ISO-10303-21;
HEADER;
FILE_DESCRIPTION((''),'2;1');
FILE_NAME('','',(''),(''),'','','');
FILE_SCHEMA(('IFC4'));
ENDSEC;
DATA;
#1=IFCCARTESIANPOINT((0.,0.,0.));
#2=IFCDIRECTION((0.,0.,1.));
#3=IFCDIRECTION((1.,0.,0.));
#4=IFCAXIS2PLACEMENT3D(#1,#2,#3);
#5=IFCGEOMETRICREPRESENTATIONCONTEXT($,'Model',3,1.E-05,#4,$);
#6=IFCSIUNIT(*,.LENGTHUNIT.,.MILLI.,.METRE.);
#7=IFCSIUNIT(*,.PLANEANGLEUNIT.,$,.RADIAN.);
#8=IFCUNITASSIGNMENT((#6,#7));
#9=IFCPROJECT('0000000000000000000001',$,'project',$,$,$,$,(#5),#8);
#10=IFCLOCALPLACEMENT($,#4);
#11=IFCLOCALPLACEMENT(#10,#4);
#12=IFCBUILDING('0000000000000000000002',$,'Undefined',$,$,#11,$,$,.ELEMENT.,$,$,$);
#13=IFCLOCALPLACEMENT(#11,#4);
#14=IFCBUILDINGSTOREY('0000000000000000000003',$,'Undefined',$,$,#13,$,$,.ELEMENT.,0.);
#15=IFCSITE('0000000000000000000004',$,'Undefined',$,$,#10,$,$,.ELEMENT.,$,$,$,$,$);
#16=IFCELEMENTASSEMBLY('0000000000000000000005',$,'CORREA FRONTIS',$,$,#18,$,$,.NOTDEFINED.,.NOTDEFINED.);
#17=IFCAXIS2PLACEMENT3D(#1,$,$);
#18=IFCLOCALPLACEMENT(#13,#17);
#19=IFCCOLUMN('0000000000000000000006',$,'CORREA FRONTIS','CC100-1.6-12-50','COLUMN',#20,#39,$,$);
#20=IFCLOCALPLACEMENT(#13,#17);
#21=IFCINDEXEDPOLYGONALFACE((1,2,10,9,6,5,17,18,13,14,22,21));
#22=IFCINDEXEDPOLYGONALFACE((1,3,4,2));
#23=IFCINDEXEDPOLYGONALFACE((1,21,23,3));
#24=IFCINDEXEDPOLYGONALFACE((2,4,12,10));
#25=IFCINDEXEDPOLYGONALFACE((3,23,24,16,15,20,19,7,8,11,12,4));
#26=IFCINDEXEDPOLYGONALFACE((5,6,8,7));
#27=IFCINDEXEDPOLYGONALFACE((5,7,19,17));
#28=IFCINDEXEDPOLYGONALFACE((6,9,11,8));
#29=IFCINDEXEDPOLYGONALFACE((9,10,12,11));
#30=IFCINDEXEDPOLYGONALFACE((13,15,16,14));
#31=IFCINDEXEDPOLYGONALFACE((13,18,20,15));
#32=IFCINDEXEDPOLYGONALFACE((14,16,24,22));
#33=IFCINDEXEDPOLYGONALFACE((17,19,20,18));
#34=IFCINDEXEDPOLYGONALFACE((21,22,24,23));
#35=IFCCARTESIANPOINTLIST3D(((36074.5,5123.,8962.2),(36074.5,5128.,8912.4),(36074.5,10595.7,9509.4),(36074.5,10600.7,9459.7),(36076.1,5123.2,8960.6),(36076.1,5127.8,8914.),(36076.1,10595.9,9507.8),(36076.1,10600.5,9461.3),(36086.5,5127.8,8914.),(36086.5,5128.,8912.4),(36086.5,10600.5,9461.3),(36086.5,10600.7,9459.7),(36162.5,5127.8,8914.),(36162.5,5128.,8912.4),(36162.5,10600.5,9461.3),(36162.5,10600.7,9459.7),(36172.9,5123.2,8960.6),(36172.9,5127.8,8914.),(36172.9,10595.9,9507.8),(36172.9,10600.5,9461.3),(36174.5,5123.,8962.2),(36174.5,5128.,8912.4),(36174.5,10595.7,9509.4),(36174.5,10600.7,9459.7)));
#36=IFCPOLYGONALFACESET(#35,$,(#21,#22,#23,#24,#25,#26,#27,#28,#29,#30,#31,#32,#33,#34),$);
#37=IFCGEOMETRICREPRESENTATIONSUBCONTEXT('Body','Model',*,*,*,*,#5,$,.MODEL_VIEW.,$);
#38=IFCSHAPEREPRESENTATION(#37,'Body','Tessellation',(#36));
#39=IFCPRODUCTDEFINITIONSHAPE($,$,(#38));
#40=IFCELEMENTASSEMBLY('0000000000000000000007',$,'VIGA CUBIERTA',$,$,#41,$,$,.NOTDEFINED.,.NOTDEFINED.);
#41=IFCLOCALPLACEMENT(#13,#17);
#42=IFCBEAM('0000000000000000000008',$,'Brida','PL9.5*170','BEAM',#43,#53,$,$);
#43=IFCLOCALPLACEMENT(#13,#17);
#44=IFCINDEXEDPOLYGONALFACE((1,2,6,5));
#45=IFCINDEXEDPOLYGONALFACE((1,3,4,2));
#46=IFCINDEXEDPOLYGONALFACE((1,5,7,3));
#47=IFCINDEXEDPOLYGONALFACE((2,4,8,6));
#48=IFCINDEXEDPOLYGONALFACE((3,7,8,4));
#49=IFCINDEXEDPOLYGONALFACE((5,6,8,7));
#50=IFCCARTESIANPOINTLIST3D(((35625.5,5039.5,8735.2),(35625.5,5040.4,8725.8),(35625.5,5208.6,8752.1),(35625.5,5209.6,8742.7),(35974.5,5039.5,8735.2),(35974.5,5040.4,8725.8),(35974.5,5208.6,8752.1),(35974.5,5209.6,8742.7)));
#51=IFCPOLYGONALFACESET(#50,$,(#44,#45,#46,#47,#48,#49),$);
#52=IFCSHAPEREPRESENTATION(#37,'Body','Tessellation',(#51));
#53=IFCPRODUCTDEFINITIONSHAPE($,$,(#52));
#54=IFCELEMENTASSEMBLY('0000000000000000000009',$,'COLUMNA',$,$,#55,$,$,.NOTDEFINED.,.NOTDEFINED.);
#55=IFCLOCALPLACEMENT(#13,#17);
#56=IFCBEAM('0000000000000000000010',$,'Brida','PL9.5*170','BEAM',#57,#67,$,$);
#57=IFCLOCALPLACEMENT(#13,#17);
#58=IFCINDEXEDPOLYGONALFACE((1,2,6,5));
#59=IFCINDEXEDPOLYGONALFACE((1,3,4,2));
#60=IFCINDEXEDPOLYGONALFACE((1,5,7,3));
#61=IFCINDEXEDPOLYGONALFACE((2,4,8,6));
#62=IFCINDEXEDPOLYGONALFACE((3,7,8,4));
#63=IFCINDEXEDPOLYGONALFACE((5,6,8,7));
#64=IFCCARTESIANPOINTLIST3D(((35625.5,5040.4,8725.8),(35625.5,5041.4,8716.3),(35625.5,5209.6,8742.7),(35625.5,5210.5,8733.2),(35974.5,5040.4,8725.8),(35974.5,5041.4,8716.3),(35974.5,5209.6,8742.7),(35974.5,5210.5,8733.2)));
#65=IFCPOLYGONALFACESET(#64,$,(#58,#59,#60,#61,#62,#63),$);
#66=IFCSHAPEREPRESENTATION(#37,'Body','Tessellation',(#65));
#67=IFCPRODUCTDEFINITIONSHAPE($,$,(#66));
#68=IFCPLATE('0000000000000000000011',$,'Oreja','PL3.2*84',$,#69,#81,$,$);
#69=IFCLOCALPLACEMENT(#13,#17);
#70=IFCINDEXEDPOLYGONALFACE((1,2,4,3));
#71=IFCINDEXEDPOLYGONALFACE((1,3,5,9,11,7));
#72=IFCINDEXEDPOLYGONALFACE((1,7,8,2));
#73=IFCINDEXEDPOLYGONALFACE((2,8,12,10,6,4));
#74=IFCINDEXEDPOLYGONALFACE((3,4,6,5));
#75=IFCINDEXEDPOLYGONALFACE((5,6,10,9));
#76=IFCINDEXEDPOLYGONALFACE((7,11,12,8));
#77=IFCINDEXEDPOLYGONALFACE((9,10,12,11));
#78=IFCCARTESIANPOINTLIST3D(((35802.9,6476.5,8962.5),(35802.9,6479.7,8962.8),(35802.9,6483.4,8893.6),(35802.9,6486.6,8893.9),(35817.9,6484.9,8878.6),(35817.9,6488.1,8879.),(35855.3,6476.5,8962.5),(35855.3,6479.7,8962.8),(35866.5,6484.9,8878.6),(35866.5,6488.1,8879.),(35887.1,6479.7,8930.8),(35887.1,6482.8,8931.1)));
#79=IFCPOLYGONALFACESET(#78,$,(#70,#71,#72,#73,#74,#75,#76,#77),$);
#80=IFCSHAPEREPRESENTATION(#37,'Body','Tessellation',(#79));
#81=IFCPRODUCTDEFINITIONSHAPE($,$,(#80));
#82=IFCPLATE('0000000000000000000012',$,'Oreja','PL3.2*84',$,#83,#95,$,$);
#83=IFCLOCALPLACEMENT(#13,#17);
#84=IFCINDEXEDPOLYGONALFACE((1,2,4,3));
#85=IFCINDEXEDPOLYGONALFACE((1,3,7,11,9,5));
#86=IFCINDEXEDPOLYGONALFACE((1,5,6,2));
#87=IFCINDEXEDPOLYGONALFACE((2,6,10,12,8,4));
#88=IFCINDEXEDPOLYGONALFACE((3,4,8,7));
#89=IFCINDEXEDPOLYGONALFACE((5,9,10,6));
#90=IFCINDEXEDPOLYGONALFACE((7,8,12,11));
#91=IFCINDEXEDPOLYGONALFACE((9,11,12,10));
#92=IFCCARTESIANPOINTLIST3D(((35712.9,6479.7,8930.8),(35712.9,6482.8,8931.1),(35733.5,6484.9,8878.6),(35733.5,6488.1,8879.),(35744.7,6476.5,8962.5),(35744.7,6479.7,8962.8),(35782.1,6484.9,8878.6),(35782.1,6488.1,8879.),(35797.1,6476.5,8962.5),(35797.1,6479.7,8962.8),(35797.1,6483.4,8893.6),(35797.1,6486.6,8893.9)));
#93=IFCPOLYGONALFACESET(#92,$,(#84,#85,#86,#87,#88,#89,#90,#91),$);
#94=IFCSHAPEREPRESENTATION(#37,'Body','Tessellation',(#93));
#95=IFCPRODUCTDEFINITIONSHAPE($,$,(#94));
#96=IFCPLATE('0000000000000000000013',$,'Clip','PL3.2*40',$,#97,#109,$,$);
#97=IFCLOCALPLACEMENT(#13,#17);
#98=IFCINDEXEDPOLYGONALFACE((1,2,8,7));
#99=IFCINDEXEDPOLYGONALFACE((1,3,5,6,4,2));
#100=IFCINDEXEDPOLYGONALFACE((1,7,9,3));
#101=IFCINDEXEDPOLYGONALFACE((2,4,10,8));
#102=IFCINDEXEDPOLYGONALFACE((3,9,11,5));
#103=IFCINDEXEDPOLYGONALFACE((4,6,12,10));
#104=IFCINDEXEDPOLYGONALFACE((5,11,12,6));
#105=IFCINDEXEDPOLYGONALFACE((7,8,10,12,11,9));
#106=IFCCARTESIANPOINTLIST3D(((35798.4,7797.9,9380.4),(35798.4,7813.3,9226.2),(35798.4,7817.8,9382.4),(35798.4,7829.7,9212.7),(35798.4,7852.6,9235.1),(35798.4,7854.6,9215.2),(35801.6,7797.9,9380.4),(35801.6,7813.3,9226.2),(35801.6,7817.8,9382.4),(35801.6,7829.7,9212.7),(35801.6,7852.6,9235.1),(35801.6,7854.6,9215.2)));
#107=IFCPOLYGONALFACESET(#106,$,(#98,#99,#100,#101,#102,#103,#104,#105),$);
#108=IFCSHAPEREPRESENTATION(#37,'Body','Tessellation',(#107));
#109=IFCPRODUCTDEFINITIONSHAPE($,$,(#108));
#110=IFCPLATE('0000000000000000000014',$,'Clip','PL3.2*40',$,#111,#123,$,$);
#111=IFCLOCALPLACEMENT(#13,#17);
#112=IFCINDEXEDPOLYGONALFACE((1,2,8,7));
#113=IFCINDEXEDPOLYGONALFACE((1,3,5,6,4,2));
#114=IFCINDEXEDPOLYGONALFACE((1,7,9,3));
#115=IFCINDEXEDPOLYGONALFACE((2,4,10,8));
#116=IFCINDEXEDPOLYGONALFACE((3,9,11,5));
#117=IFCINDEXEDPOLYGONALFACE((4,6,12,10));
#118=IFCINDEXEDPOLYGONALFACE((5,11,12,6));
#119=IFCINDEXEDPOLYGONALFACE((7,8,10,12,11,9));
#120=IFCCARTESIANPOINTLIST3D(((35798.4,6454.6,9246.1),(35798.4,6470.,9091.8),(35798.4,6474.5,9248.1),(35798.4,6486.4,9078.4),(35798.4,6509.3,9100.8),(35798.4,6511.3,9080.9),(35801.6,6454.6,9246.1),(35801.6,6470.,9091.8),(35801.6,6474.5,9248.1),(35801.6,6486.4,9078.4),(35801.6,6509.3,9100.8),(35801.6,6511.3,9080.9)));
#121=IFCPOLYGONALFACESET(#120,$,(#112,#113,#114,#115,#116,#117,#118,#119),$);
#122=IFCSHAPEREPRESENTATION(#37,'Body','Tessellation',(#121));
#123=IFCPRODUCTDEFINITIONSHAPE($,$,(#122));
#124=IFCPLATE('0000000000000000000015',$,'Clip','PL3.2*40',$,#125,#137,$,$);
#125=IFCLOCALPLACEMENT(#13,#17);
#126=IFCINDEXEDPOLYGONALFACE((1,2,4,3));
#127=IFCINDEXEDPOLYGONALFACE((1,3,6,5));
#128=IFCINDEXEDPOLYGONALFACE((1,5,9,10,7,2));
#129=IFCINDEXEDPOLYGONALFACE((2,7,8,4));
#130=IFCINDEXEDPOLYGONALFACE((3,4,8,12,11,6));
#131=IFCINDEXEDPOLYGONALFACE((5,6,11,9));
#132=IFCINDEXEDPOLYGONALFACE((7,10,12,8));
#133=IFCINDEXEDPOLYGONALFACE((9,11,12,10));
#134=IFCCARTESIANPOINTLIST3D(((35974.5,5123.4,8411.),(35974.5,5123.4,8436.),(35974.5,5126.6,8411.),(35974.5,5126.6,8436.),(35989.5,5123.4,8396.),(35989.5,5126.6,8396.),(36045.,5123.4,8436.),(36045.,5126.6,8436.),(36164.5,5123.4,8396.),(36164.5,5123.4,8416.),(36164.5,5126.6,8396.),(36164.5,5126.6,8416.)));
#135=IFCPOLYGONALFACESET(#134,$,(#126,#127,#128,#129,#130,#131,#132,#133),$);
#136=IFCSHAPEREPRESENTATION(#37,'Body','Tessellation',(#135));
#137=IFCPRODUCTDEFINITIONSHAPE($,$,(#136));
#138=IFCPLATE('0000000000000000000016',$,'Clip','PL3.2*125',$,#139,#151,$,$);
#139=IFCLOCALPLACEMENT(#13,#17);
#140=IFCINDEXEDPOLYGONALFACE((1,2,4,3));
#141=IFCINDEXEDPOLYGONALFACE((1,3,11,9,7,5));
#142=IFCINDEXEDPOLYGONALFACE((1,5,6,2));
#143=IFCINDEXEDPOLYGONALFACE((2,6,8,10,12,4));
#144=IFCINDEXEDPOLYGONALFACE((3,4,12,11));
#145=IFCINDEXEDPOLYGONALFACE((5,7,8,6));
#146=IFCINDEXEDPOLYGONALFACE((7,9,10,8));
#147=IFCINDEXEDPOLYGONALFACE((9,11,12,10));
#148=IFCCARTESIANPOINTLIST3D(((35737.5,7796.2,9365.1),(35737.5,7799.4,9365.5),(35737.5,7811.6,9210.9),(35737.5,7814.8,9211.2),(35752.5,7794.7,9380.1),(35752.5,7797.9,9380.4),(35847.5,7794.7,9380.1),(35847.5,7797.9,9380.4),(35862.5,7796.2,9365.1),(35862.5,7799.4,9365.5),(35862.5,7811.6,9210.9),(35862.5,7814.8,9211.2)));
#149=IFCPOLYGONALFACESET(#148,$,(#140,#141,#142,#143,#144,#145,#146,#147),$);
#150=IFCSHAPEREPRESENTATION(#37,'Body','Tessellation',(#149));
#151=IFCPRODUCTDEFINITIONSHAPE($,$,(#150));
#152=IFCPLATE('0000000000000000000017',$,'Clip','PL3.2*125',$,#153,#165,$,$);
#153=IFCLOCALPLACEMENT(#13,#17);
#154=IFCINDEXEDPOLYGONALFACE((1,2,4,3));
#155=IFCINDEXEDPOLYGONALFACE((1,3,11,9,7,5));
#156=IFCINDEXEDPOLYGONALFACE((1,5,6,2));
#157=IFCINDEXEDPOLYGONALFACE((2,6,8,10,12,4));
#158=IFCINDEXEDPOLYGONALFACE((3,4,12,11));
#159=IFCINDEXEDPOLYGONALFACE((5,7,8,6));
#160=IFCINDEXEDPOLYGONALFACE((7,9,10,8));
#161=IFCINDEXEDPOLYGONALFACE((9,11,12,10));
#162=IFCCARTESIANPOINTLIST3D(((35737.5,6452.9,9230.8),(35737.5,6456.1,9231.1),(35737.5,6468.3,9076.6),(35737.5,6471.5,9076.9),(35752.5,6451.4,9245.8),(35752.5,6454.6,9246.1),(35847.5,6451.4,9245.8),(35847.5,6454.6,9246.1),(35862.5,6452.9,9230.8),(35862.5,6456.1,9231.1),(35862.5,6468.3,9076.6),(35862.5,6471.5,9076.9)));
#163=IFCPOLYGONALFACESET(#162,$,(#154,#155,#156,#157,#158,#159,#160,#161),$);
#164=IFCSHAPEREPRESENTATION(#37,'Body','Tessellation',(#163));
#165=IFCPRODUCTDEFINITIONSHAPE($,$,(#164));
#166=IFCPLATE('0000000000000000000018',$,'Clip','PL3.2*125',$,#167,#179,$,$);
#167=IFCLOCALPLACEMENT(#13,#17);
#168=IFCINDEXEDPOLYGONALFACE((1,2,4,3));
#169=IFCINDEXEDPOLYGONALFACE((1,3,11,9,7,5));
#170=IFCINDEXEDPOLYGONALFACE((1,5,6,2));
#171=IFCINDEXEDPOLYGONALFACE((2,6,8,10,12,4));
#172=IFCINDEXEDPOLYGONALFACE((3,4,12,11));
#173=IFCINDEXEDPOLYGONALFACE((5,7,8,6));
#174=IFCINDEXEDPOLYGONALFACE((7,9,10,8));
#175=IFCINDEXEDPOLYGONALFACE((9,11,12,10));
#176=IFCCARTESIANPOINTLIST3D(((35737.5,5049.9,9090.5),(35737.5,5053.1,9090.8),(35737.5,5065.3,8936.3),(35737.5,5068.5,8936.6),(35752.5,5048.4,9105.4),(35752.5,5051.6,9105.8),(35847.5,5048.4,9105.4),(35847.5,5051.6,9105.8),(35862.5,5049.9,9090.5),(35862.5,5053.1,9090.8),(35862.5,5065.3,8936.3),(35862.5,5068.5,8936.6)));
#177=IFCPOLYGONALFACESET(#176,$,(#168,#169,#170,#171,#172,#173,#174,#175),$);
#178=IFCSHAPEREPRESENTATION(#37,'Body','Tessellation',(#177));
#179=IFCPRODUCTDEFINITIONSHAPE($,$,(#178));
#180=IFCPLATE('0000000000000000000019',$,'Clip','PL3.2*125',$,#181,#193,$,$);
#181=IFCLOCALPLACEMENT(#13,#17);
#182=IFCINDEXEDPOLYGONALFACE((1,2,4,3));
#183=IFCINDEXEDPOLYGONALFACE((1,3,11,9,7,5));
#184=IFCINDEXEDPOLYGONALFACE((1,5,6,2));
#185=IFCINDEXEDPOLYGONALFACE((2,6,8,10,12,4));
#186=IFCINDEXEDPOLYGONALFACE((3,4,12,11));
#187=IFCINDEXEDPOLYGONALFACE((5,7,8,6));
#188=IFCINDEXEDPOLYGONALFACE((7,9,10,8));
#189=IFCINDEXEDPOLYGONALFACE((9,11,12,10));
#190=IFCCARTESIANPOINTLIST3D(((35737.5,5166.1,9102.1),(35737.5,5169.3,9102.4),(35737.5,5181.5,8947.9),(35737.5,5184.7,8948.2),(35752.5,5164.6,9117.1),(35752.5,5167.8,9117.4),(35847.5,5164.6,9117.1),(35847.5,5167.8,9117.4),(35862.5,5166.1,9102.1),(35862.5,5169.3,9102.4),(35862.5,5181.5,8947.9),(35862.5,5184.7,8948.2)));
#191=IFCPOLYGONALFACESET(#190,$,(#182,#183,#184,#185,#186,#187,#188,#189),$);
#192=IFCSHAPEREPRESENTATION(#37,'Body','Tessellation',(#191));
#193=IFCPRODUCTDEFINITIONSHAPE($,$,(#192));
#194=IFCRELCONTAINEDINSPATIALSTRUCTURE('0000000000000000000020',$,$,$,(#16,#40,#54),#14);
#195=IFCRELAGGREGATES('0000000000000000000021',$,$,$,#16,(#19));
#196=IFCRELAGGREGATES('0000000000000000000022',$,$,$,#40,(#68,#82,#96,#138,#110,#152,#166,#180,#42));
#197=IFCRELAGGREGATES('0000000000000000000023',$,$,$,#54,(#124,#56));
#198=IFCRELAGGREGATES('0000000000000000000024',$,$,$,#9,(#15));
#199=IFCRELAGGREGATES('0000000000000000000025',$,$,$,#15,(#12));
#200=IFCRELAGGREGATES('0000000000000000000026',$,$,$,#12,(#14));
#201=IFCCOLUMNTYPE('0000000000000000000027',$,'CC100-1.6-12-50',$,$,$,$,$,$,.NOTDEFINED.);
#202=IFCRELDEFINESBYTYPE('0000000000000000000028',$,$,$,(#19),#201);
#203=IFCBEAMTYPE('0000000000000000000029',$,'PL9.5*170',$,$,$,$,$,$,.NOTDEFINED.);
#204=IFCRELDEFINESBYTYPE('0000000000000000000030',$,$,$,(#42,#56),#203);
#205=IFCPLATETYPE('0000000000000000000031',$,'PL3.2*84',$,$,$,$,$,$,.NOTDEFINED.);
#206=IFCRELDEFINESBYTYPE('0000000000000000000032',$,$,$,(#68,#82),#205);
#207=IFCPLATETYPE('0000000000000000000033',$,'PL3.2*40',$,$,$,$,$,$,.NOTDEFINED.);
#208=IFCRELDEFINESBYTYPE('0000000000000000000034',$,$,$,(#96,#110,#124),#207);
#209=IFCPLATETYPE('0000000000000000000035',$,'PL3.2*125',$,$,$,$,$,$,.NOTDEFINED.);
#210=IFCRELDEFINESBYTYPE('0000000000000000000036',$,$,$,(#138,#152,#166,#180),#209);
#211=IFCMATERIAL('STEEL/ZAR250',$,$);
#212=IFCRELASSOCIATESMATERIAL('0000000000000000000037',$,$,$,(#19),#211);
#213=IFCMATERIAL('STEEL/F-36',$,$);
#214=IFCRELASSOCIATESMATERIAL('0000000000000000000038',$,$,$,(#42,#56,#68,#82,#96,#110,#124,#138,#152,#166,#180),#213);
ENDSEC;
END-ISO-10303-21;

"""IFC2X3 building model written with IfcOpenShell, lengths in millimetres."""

from ifc_helpers import new_model, si_unit, frame, origin_with_axes, origin_2d_with_axis, place, context, subcontext, project, spatial, polyline, rectangle, c_section, outline, extrude, material, type_object, element, aggregate, save


model = new_model("IFC2X3")

# Units and contexts
model_context = context("Model", 3, precision=1e-05, world=origin_with_axes())
body_context = subcontext(model_context, "Body", "Model", "MODEL_VIEW")
ifc_project = project(units=[si_unit("LENGTHUNIT", "METRE", prefix="MILLI"), si_unit("PLANEANGLEUNIT", "RADIAN")], contexts=[model_context])

# Site, building, storey
site_placement = place(None, origin_with_axes())
site = spatial("IfcSite", under=ifc_project, at=site_placement, Name="Undefined", CompositionType="ELEMENT")
building_placement = place(site_placement, origin_with_axes())
building = spatial("IfcBuilding", under=site, at=building_placement, Name="Undefined", CompositionType="ELEMENT")
storey_placement = place(building_placement, origin_with_axes())
storey = spatial("IfcBuildingStorey", under=building, at=storey_placement, Name="Undefined", CompositionType="ELEMENT", Elevation=0.0)

# Element assembly, column
assembly_1_placement = place(storey_placement, origin_with_axes())
assembly_1 = element("IfcElementAssembly", 1, at=assembly_1_placement, inside=storey, Name="CORREA FRONTIS", AssemblyPlace="NOTDEFINED", PredefinedType="NOTDEFINED")
ifc_material_1 = material(Name="STEEL/ZAR250")
column_type = type_object("IfcColumnType", Name="CC100-1.6-12-50", PredefinedType="NOTDEFINED")
column_placement = place(assembly_1_placement, frame((36124.5, 5125.5, 8937.3), z_axis=(0.0, 0.995037, 0.099504), x_axis=(1.0, 0.0, 0.0)))
column = element("IfcColumn", 2, at=column_placement, type_object=column_type, material=ifc_material_1, Name="CORREA FRONTIS", Description="CC100-1.6-12-50", ObjectType="COLUMN", context=body_context, shape_type="SweptSolid", body=[
    extrude(c_section(Depth=100.0, Width=50.0, WallThickness=1.6, Girth=12.0, at=origin_2d_with_axis()), frame((0.0, 0.0, 5500.0), z_axis=(0.0, 0.0, -1.0), x_axis=(0.0, 1.0, 0.0)), (0.0, 0.0, 1.0), 5500.0),
])
aggregate(assembly_1, [column])

# Element assemblies, beams
assembly_2_placement = place(storey_placement, origin_with_axes())
assembly_2 = element("IfcElementAssembly", 3, at=assembly_2_placement, inside=storey, Name="VIGA CUBIERTA", AssemblyPlace="NOTDEFINED", PredefinedType="NOTDEFINED")
ifc_material_2 = material(Name="STEEL/F-36")
beam_type = type_object("IfcBeamType", Name="PL9.5*170", PredefinedType="NOTDEFINED")
beam_1_placement = place(assembly_2_placement, frame((35974.5, 5124.5, 8738.9), z_axis=(0.0, -0.995037, -0.099504), x_axis=(-1.0, 0.0, 0.0)))
beam_1 = element("IfcBeam", 4, at=beam_1_placement, type_object=beam_type, material=ifc_material_2, Name="Brida", Description="PL9.5*170", ObjectType="BEAM", context=body_context, shape_type="SweptSolid", body=[
    extrude(rectangle(XDim=9.5, YDim=170.0, at=origin_2d_with_axis()), frame((349.0, 0.0, 0.0), z_axis=(-1.0, 0.0, 0.0), x_axis=(0.0, -1.0, 0.0)), (0.0, 0.0, 1.0), 349.0),
])
assembly_3_placement = place(storey_placement, origin_with_axes())
assembly_3 = element("IfcElementAssembly", 5, at=assembly_3_placement, inside=storey, Name="COLUMNA", AssemblyPlace="NOTDEFINED", PredefinedType="NOTDEFINED")
beam_2_placement = place(assembly_3_placement, frame((35974.5, 5125.5, 8729.5), z_axis=(0.0, -0.995037, -0.099504), x_axis=(-1.0, 0.0, 0.0)))
beam_2 = element("IfcBeam", 6, at=beam_2_placement, type_object=beam_type, material=ifc_material_2, Name="Brida", Description="PL9.5*170", ObjectType="BEAM", context=body_context, shape_type="SweptSolid", body=[
    extrude(rectangle(XDim=9.5, YDim=170.0, at=origin_2d_with_axis()), frame((349.0, 0.0, 0.0), z_axis=(-1.0, 0.0, 0.0), x_axis=(0.0, -1.0, 0.0)), (0.0, 0.0, 1.0), 349.0),
])

# Plates
plate_type_1 = type_object("IfcPlateType", Name="PL3.2*84", PredefinedType="NOTDEFINED")
plate_1_placement = place(assembly_2_placement, frame((35802.9, 6486.5, 8878.8), z_axis=(0.0, -0.995037, -0.099504), x_axis=(1.0, 0.0, -0.000004)))
plate_1 = element("IfcPlate", 7, at=plate_1_placement, type_object=plate_type_1, material=ifc_material_2, Name="Oreja", Description="PL3.2*84", context=body_context, shape_type="SweptSolid", body=[
    extrude(outline(polyline([(0.0, 15.0), (15.0, 0.0), (63.6, 0.0), (84.2, 52.4), (52.4, 84.2), (0.0, 84.2), (0.0, 15.0)])), frame((0.0, 0.0, -1.6), z_axis=(0.0, 0.0, 1.0), x_axis=(1.0, 0.0, 0.0)), (0.0, 0.0, 1.0), 3.2),
])
plate_2_placement = place(assembly_2_placement, frame((35797.1, 6486.5, 8878.8), z_axis=(0.0, 0.995037, 0.099504), x_axis=(-1.0, 0.000001, -0.000004)))
plate_2 = element("IfcPlate", 8, at=plate_2_placement, type_object=plate_type_1, material=ifc_material_2, Name="Oreja", Description="PL3.2*84", context=body_context, shape_type="SweptSolid", body=[
    extrude(outline(polyline([(0.0, 15.0), (15.0, 0.0), (63.6, 0.0), (84.2, 52.4), (52.4, 84.2), (0.0, 84.2), (0.0, 15.0)])), frame((0.0, 0.0, -1.6), z_axis=(0.0, 0.0, 1.0), x_axis=(1.0, 0.0, 0.0)), (0.0, 0.0, 1.0), 3.2),
])
plate_type_2 = type_object("IfcPlateType", Name="PL3.2*40", PredefinedType="NOTDEFINED")
plate_3_placement = place(assembly_2_placement, frame((35800.0, 7854.6, 9215.2), z_axis=(-1.0, 0.0, 0.0), x_axis=(0.0, -0.995037, -0.099504)))
plate_3 = element("IfcPlate", 9, at=plate_3_placement, type_object=plate_type_2, material=ifc_material_2, Name="Clip", Description="PL3.2*40", context=body_context, shape_type="SweptSolid", body=[
    extrude(outline(polyline([(0.0, 0.0), (25.0, 0.0), (40.0, 15.0), (40.0, 170.0), (20.0, 170.0), (0.0, 20.0), (0.0, 0.0)])), frame((0.0, 0.0, -1.6), z_axis=(0.0, 0.0, 1.0), x_axis=(1.0, 0.0, 0.0)), (0.0, 0.0, 1.0), 3.2),
])
plate_4_placement = place(assembly_2_placement, frame((35800.0, 6511.3, 9080.9), z_axis=(-1.0, 0.0, 0.0), x_axis=(0.0, -0.995037, -0.099504)))
plate_4 = element("IfcPlate", 10, at=plate_4_placement, type_object=plate_type_2, material=ifc_material_2, Name="Clip", Description="PL3.2*40", context=body_context, shape_type="SweptSolid", body=[
    extrude(outline(polyline([(0.0, 0.0), (25.0, 0.0), (40.0, 15.0), (40.0, 170.0), (20.0, 170.0), (0.0, 20.0), (0.0, 0.0)])), frame((0.0, 0.0, -1.6), z_axis=(0.0, 0.0, 1.0), x_axis=(1.0, 0.0, 0.0)), (0.0, 0.0, 1.0), 3.2),
])
plate_5_placement = place(assembly_3_placement, frame((35974.5, 5125.0, 8436.0), z_axis=(0.0, -1.0, 0.0), x_axis=(0.000007, 0.0, -1.0)))
plate_5 = element("IfcPlate", 11, at=plate_5_placement, type_object=plate_type_2, material=ifc_material_2, Name="Clip", Description="PL3.2*40", context=body_context, shape_type="SweptSolid", body=[
    extrude(outline(polyline([(0.0, 0.0), (25.0, 0.0), (40.0, 15.0), (40.0, 190.0), (20.0, 190.0), (0.0, 70.5), (0.0, 0.0)])), frame((0.0, 0.0, -1.6), z_axis=(0.0, 0.0, 1.0), x_axis=(1.0, 0.0, 0.0)), (0.0, 0.0, 1.0), 3.2),
])
plate_type_3 = type_object("IfcPlateType", Name="PL3.2*125", PredefinedType="NOTDEFINED")
plate_6_placement = place(assembly_2_placement, frame((35862.5, 7813.2, 9211.1), z_axis=(0.0, 0.995037, 0.099504), x_axis=(-1.0, 0.0, 0.0)))
plate_6 = element("IfcPlate", 12, at=plate_6_placement, type_object=plate_type_3, material=ifc_material_2, Name="Clip", Description="PL3.2*125", context=body_context, shape_type="SweptSolid", body=[
    extrude(outline(polyline([(0.0, 0.0), (125.0, 0.0), (125.0, 155.0), (110.0, 170.0), (15.0, 170.0), (0.0, 155.0), (0.0, 0.0)])), frame((0.0, 0.0, -1.6), z_axis=(0.0, 0.0, 1.0), x_axis=(1.0, 0.0, 0.0)), (0.0, 0.0, 1.0), 3.2),
])
plate_7_placement = place(assembly_2_placement, frame((35862.5, 6469.9, 9076.8), z_axis=(0.0, 0.995037, 0.099504), x_axis=(-1.0, 0.0, 0.0)))
plate_7 = element("IfcPlate", 13, at=plate_7_placement, type_object=plate_type_3, material=ifc_material_2, Name="Clip", Description="PL3.2*125", context=body_context, shape_type="SweptSolid", body=[
    extrude(outline(polyline([(0.0, 0.0), (125.0, 0.0), (125.0, 155.0), (110.0, 170.0), (15.0, 170.0), (0.0, 155.0), (0.0, 0.0)])), frame((0.0, 0.0, -1.6), z_axis=(0.0, 0.0, 1.0), x_axis=(1.0, 0.0, 0.0)), (0.0, 0.0, 1.0), 3.2),
])
plate_8_placement = place(assembly_2_placement, frame((35862.5, 5066.9, 8936.4), z_axis=(0.0, 0.995037, 0.099504), x_axis=(-1.0, 0.0, 0.0)))
plate_8 = element("IfcPlate", 14, at=plate_8_placement, type_object=plate_type_3, material=ifc_material_2, Name="Clip", Description="PL3.2*125", context=body_context, shape_type="SweptSolid", body=[
    extrude(outline(polyline([(0.0, 0.0), (125.0, 0.0), (125.0, 155.0), (110.0, 170.0), (15.0, 170.0), (0.0, 155.0), (0.0, 0.0)])), frame((0.0, 0.0, -1.6), z_axis=(0.0, 0.0, 1.0), x_axis=(1.0, 0.0, 0.0)), (0.0, 0.0, 1.0), 3.2),
])
plate_9_placement = place(assembly_2_placement, frame((35862.5, 5183.1, 8948.1), z_axis=(0.0, 0.995037, 0.099504), x_axis=(-1.0, 0.0, 0.0)))
plate_9 = element("IfcPlate", 15, at=plate_9_placement, type_object=plate_type_3, material=ifc_material_2, Name="Clip", Description="PL3.2*125", context=body_context, shape_type="SweptSolid", body=[
    extrude(outline(polyline([(0.0, 0.0), (125.0, 0.0), (125.0, 155.0), (110.0, 170.0), (15.0, 170.0), (0.0, 155.0), (0.0, 0.0)])), frame((0.0, 0.0, -1.6), z_axis=(0.0, 0.0, 1.0), x_axis=(1.0, 0.0, 0.0)), (0.0, 0.0, 1.0), 3.2),
])

aggregate(assembly_2, [plate_1, plate_2, plate_3, plate_6, plate_4, plate_7, plate_8, plate_9, beam_1])
aggregate(assembly_3, [plate_5, beam_2])

save(model, "model.ifc")
